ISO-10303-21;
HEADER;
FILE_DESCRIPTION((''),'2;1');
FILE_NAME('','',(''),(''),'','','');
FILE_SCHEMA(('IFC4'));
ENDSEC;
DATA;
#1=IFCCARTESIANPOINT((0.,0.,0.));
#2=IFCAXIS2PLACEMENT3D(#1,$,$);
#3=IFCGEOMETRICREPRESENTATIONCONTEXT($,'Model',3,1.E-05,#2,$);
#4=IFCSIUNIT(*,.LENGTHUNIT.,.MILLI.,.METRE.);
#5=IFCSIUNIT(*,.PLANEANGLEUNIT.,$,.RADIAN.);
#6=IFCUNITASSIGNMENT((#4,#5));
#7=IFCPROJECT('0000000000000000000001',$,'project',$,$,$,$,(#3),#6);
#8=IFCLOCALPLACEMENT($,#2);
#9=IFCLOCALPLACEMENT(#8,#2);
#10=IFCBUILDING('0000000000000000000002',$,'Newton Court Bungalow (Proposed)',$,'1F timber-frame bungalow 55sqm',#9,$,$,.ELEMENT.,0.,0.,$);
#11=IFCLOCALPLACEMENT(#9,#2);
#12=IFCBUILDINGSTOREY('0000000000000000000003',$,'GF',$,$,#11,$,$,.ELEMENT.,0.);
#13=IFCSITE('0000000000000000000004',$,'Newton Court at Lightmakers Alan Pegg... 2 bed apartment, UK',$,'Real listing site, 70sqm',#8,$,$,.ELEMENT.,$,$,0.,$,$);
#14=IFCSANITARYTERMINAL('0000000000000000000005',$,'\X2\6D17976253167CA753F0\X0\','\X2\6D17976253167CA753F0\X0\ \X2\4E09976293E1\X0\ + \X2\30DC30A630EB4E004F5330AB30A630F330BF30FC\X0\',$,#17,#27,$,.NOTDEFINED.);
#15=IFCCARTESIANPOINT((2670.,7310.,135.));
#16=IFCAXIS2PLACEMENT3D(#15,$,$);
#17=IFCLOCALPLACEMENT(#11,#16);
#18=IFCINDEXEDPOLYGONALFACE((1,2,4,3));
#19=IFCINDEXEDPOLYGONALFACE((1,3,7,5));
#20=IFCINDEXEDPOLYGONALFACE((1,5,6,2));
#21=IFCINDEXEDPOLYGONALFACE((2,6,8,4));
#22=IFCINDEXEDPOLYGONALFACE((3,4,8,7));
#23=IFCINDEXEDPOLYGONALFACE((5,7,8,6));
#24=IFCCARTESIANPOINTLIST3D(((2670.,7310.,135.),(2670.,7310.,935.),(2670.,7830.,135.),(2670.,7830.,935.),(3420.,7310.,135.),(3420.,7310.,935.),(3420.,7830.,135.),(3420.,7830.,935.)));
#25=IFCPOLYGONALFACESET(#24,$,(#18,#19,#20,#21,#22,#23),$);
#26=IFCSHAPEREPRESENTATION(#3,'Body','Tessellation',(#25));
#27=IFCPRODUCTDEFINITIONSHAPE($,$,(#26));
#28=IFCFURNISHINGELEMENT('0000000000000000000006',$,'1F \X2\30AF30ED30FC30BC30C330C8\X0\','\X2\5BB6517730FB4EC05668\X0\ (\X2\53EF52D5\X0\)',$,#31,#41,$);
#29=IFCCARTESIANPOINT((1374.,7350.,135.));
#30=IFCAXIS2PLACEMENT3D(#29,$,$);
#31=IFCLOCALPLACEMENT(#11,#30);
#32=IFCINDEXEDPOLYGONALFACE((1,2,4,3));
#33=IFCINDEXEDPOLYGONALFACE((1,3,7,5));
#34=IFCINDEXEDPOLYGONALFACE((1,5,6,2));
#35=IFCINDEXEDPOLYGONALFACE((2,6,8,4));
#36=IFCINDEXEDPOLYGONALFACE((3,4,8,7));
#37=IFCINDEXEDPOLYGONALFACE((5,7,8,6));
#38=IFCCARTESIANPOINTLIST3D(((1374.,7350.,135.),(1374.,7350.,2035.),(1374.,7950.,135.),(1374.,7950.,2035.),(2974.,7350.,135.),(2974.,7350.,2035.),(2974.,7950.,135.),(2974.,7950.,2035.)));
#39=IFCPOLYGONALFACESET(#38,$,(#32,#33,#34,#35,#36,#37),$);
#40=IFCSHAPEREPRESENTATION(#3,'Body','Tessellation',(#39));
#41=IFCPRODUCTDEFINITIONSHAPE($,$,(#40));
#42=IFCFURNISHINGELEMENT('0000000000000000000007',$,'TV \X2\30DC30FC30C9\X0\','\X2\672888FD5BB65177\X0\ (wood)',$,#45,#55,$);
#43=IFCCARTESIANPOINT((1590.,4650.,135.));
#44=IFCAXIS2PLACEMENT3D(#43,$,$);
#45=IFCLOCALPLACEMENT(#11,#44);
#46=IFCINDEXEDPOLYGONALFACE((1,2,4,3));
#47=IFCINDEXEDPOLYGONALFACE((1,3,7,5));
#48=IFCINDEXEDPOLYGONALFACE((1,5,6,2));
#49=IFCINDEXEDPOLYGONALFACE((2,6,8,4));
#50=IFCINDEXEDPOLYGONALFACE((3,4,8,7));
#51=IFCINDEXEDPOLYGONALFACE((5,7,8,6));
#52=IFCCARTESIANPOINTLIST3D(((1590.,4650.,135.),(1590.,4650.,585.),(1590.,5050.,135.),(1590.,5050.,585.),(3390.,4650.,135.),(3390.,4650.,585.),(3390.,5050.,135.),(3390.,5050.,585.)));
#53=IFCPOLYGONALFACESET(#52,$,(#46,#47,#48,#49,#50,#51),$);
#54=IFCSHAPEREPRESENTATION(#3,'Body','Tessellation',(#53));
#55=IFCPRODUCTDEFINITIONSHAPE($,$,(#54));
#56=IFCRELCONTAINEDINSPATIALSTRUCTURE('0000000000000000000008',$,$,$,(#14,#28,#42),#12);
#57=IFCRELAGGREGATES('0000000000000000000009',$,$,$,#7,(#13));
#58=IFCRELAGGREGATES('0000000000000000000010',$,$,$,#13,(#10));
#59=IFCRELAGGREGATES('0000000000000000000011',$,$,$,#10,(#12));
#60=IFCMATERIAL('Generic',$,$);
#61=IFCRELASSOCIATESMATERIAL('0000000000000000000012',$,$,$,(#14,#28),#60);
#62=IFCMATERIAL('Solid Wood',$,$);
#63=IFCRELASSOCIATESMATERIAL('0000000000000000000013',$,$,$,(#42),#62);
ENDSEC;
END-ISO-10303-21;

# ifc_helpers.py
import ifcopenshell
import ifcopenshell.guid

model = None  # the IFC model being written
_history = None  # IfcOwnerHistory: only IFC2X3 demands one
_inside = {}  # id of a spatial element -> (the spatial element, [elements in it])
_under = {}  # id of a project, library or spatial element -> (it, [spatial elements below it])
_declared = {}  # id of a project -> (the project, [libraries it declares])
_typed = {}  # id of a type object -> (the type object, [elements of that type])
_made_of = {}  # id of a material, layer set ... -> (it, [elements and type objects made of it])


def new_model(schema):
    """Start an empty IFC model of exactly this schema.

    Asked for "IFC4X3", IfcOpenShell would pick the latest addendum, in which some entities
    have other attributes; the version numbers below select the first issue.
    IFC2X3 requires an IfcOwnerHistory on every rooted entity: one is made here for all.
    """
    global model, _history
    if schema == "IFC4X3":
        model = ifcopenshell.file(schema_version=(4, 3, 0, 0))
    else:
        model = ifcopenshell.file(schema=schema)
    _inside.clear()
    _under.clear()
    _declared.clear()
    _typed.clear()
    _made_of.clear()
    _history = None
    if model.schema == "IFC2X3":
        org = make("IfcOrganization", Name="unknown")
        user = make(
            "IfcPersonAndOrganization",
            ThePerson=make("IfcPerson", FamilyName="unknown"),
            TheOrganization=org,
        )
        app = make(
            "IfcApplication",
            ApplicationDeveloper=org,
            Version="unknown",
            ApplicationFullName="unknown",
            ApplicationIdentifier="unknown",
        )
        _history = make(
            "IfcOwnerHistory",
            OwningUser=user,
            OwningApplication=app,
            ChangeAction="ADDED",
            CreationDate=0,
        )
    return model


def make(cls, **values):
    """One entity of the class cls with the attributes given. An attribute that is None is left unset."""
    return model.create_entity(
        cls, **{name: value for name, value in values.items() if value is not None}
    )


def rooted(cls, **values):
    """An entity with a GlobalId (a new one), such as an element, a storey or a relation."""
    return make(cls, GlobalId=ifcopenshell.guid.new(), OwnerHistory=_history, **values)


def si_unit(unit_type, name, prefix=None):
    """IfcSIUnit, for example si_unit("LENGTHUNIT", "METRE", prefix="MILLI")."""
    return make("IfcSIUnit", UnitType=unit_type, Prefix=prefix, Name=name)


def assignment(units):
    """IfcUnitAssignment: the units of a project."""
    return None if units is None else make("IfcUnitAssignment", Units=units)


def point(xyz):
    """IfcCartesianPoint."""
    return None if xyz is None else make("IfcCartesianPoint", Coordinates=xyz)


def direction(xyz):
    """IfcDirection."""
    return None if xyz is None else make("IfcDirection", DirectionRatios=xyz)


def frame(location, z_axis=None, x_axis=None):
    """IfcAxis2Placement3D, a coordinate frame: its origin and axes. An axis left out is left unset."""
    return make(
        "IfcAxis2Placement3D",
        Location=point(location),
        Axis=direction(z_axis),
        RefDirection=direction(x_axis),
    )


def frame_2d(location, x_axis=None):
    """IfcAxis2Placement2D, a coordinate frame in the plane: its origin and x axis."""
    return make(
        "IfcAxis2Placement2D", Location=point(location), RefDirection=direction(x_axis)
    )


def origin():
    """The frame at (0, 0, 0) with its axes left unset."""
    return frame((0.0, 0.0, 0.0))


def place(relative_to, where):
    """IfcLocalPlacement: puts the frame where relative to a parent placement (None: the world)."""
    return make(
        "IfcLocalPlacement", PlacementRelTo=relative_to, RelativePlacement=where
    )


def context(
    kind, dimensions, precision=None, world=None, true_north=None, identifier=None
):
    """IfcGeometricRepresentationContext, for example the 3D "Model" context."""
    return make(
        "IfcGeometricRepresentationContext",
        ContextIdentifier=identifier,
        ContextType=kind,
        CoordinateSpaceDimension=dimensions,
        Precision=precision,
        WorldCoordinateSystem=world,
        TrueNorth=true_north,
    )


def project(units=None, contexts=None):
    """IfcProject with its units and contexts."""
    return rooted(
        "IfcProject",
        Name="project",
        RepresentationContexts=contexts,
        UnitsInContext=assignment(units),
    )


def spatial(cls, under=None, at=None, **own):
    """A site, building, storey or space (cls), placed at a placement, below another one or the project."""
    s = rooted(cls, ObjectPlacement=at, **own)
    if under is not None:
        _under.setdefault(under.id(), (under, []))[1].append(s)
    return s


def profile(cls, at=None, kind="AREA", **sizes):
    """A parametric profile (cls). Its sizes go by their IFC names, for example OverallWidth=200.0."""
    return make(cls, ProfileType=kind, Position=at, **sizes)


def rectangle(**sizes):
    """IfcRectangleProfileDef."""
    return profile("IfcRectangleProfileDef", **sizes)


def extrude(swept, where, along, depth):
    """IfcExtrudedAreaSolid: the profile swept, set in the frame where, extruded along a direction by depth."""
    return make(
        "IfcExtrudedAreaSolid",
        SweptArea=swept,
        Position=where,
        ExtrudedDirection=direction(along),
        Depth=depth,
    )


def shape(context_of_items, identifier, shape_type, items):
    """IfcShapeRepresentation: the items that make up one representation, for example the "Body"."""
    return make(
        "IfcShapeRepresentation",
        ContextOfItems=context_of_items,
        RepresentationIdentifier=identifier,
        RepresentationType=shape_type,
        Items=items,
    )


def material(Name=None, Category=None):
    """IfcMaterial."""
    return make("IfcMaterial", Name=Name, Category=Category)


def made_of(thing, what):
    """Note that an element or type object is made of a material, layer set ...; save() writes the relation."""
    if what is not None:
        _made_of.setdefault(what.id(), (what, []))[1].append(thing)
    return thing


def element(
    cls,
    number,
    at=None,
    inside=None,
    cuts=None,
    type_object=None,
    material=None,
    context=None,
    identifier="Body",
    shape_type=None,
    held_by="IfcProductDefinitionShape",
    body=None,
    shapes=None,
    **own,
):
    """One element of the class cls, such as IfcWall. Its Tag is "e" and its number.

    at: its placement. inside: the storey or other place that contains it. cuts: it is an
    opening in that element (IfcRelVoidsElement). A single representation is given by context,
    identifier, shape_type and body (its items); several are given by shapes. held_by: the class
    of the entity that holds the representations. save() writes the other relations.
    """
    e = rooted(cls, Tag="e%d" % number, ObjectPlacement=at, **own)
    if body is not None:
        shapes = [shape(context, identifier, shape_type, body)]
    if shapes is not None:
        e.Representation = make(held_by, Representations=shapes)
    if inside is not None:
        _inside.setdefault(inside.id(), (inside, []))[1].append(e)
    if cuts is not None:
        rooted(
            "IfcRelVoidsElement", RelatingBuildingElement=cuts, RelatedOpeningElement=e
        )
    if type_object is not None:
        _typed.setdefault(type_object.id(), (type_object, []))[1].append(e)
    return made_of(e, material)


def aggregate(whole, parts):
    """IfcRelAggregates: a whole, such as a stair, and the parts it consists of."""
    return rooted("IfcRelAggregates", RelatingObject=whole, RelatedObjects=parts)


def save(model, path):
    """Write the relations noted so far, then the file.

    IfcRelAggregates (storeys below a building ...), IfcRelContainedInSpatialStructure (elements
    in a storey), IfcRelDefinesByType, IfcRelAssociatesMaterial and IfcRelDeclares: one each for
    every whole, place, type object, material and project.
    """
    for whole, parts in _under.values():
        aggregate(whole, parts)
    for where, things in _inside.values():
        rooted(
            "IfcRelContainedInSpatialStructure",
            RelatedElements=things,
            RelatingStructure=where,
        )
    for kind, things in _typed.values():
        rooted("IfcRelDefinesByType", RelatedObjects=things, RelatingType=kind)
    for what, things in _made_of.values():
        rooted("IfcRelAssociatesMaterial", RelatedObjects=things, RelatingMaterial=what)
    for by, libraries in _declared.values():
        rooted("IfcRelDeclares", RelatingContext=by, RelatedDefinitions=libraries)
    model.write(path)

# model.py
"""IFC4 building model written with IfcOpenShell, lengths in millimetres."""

from ifc_helpers import new_model, si_unit, frame, frame_2d, origin, place, context, project, spatial, rectangle, extrude, material, element, save


model = new_model("IFC4")

# Units and contexts
model_context = context("Model", 3, precision=1e-05, world=origin())
ifc_project = project(units=[si_unit("LENGTHUNIT", "METRE", prefix="MILLI"), si_unit("PLANEANGLEUNIT", "RADIAN")], contexts=[model_context])

# Site, building, storey
site_placement = place(None, origin())
site = spatial("IfcSite", under=ifc_project, at=site_placement, Name="Newton Court at Lightmakers Alan Pegg... 2 bed apartment, UK", ObjectType="Real listing site, 70sqm", CompositionType="ELEMENT", RefElevation=0.0)
building_placement = place(site_placement, origin())
building = spatial("IfcBuilding", under=site, at=building_placement, Name="Newton Court Bungalow (Proposed)", ObjectType="1F timber-frame bungalow 55sqm", CompositionType="ELEMENT", ElevationOfRefHeight=0.0, ElevationOfTerrain=0.0)
storey_placement = place(building_placement, origin())
storey = spatial("IfcBuildingStorey", under=building, at=storey_placement, Name="GF", CompositionType="ELEMENT", Elevation=0.0)

# Shared definitions
ifc_material_1 = material(Name="Solid Wood")

# Shared definitions
ifc_material_2 = material(Name="Generic")

# Sanitary terminal
sanitary_terminal_1_placement = place(storey_placement, frame((2670.0, 7310.0, 135.0)))
element("IfcSanitaryTerminal", 1, at=sanitary_terminal_1_placement, inside=storey, material=ifc_material_2, Name="洗面化粧台", Description="洗面化粧台 三面鏡 + ボウル一体カウンター", PredefinedType="NOTDEFINED", context=model_context, shape_type="SweptSolid", body=[
    extrude(rectangle(XDim=750.0, YDim=520.0, at=frame_2d((375.0, 260.0))), frame((2670.0, 7310.0, 135.0)), (0.0, 0.0, 1.0), 800.0),
])

# Furnishing elements
furnishing_1_placement = place(storey_placement, frame((1374.0, 7350.0, 135.0)))
element("IfcFurnishingElement", 2, at=furnishing_1_placement, inside=storey, material=ifc_material_2, Name="1F クローゼット", Description="家具・什器 (可動)", context=model_context, shape_type="SweptSolid", body=[
    extrude(rectangle(XDim=1600.0, YDim=600.0, at=frame_2d((800.0, 300.0))), frame((1374.0, 7350.0, 135.0)), (0.0, 0.0, 1.0), 1900.0),
])
furnishing_2_placement = place(storey_placement, frame((1590.0, 4650.0, 135.0)))
element("IfcFurnishingElement", 3, at=furnishing_2_placement, inside=storey, material=ifc_material_1, Name="TV ボード", Description="木製家具 (wood)", context=model_context, shape_type="SweptSolid", body=[
    extrude(rectangle(XDim=1800.0, YDim=400.0, at=frame_2d((900.0, 200.0))), frame((1590.0, 4650.0, 135.0)), (0.0, 0.0, 1.0), 450.0),
])

save(model, "model.ifc")
